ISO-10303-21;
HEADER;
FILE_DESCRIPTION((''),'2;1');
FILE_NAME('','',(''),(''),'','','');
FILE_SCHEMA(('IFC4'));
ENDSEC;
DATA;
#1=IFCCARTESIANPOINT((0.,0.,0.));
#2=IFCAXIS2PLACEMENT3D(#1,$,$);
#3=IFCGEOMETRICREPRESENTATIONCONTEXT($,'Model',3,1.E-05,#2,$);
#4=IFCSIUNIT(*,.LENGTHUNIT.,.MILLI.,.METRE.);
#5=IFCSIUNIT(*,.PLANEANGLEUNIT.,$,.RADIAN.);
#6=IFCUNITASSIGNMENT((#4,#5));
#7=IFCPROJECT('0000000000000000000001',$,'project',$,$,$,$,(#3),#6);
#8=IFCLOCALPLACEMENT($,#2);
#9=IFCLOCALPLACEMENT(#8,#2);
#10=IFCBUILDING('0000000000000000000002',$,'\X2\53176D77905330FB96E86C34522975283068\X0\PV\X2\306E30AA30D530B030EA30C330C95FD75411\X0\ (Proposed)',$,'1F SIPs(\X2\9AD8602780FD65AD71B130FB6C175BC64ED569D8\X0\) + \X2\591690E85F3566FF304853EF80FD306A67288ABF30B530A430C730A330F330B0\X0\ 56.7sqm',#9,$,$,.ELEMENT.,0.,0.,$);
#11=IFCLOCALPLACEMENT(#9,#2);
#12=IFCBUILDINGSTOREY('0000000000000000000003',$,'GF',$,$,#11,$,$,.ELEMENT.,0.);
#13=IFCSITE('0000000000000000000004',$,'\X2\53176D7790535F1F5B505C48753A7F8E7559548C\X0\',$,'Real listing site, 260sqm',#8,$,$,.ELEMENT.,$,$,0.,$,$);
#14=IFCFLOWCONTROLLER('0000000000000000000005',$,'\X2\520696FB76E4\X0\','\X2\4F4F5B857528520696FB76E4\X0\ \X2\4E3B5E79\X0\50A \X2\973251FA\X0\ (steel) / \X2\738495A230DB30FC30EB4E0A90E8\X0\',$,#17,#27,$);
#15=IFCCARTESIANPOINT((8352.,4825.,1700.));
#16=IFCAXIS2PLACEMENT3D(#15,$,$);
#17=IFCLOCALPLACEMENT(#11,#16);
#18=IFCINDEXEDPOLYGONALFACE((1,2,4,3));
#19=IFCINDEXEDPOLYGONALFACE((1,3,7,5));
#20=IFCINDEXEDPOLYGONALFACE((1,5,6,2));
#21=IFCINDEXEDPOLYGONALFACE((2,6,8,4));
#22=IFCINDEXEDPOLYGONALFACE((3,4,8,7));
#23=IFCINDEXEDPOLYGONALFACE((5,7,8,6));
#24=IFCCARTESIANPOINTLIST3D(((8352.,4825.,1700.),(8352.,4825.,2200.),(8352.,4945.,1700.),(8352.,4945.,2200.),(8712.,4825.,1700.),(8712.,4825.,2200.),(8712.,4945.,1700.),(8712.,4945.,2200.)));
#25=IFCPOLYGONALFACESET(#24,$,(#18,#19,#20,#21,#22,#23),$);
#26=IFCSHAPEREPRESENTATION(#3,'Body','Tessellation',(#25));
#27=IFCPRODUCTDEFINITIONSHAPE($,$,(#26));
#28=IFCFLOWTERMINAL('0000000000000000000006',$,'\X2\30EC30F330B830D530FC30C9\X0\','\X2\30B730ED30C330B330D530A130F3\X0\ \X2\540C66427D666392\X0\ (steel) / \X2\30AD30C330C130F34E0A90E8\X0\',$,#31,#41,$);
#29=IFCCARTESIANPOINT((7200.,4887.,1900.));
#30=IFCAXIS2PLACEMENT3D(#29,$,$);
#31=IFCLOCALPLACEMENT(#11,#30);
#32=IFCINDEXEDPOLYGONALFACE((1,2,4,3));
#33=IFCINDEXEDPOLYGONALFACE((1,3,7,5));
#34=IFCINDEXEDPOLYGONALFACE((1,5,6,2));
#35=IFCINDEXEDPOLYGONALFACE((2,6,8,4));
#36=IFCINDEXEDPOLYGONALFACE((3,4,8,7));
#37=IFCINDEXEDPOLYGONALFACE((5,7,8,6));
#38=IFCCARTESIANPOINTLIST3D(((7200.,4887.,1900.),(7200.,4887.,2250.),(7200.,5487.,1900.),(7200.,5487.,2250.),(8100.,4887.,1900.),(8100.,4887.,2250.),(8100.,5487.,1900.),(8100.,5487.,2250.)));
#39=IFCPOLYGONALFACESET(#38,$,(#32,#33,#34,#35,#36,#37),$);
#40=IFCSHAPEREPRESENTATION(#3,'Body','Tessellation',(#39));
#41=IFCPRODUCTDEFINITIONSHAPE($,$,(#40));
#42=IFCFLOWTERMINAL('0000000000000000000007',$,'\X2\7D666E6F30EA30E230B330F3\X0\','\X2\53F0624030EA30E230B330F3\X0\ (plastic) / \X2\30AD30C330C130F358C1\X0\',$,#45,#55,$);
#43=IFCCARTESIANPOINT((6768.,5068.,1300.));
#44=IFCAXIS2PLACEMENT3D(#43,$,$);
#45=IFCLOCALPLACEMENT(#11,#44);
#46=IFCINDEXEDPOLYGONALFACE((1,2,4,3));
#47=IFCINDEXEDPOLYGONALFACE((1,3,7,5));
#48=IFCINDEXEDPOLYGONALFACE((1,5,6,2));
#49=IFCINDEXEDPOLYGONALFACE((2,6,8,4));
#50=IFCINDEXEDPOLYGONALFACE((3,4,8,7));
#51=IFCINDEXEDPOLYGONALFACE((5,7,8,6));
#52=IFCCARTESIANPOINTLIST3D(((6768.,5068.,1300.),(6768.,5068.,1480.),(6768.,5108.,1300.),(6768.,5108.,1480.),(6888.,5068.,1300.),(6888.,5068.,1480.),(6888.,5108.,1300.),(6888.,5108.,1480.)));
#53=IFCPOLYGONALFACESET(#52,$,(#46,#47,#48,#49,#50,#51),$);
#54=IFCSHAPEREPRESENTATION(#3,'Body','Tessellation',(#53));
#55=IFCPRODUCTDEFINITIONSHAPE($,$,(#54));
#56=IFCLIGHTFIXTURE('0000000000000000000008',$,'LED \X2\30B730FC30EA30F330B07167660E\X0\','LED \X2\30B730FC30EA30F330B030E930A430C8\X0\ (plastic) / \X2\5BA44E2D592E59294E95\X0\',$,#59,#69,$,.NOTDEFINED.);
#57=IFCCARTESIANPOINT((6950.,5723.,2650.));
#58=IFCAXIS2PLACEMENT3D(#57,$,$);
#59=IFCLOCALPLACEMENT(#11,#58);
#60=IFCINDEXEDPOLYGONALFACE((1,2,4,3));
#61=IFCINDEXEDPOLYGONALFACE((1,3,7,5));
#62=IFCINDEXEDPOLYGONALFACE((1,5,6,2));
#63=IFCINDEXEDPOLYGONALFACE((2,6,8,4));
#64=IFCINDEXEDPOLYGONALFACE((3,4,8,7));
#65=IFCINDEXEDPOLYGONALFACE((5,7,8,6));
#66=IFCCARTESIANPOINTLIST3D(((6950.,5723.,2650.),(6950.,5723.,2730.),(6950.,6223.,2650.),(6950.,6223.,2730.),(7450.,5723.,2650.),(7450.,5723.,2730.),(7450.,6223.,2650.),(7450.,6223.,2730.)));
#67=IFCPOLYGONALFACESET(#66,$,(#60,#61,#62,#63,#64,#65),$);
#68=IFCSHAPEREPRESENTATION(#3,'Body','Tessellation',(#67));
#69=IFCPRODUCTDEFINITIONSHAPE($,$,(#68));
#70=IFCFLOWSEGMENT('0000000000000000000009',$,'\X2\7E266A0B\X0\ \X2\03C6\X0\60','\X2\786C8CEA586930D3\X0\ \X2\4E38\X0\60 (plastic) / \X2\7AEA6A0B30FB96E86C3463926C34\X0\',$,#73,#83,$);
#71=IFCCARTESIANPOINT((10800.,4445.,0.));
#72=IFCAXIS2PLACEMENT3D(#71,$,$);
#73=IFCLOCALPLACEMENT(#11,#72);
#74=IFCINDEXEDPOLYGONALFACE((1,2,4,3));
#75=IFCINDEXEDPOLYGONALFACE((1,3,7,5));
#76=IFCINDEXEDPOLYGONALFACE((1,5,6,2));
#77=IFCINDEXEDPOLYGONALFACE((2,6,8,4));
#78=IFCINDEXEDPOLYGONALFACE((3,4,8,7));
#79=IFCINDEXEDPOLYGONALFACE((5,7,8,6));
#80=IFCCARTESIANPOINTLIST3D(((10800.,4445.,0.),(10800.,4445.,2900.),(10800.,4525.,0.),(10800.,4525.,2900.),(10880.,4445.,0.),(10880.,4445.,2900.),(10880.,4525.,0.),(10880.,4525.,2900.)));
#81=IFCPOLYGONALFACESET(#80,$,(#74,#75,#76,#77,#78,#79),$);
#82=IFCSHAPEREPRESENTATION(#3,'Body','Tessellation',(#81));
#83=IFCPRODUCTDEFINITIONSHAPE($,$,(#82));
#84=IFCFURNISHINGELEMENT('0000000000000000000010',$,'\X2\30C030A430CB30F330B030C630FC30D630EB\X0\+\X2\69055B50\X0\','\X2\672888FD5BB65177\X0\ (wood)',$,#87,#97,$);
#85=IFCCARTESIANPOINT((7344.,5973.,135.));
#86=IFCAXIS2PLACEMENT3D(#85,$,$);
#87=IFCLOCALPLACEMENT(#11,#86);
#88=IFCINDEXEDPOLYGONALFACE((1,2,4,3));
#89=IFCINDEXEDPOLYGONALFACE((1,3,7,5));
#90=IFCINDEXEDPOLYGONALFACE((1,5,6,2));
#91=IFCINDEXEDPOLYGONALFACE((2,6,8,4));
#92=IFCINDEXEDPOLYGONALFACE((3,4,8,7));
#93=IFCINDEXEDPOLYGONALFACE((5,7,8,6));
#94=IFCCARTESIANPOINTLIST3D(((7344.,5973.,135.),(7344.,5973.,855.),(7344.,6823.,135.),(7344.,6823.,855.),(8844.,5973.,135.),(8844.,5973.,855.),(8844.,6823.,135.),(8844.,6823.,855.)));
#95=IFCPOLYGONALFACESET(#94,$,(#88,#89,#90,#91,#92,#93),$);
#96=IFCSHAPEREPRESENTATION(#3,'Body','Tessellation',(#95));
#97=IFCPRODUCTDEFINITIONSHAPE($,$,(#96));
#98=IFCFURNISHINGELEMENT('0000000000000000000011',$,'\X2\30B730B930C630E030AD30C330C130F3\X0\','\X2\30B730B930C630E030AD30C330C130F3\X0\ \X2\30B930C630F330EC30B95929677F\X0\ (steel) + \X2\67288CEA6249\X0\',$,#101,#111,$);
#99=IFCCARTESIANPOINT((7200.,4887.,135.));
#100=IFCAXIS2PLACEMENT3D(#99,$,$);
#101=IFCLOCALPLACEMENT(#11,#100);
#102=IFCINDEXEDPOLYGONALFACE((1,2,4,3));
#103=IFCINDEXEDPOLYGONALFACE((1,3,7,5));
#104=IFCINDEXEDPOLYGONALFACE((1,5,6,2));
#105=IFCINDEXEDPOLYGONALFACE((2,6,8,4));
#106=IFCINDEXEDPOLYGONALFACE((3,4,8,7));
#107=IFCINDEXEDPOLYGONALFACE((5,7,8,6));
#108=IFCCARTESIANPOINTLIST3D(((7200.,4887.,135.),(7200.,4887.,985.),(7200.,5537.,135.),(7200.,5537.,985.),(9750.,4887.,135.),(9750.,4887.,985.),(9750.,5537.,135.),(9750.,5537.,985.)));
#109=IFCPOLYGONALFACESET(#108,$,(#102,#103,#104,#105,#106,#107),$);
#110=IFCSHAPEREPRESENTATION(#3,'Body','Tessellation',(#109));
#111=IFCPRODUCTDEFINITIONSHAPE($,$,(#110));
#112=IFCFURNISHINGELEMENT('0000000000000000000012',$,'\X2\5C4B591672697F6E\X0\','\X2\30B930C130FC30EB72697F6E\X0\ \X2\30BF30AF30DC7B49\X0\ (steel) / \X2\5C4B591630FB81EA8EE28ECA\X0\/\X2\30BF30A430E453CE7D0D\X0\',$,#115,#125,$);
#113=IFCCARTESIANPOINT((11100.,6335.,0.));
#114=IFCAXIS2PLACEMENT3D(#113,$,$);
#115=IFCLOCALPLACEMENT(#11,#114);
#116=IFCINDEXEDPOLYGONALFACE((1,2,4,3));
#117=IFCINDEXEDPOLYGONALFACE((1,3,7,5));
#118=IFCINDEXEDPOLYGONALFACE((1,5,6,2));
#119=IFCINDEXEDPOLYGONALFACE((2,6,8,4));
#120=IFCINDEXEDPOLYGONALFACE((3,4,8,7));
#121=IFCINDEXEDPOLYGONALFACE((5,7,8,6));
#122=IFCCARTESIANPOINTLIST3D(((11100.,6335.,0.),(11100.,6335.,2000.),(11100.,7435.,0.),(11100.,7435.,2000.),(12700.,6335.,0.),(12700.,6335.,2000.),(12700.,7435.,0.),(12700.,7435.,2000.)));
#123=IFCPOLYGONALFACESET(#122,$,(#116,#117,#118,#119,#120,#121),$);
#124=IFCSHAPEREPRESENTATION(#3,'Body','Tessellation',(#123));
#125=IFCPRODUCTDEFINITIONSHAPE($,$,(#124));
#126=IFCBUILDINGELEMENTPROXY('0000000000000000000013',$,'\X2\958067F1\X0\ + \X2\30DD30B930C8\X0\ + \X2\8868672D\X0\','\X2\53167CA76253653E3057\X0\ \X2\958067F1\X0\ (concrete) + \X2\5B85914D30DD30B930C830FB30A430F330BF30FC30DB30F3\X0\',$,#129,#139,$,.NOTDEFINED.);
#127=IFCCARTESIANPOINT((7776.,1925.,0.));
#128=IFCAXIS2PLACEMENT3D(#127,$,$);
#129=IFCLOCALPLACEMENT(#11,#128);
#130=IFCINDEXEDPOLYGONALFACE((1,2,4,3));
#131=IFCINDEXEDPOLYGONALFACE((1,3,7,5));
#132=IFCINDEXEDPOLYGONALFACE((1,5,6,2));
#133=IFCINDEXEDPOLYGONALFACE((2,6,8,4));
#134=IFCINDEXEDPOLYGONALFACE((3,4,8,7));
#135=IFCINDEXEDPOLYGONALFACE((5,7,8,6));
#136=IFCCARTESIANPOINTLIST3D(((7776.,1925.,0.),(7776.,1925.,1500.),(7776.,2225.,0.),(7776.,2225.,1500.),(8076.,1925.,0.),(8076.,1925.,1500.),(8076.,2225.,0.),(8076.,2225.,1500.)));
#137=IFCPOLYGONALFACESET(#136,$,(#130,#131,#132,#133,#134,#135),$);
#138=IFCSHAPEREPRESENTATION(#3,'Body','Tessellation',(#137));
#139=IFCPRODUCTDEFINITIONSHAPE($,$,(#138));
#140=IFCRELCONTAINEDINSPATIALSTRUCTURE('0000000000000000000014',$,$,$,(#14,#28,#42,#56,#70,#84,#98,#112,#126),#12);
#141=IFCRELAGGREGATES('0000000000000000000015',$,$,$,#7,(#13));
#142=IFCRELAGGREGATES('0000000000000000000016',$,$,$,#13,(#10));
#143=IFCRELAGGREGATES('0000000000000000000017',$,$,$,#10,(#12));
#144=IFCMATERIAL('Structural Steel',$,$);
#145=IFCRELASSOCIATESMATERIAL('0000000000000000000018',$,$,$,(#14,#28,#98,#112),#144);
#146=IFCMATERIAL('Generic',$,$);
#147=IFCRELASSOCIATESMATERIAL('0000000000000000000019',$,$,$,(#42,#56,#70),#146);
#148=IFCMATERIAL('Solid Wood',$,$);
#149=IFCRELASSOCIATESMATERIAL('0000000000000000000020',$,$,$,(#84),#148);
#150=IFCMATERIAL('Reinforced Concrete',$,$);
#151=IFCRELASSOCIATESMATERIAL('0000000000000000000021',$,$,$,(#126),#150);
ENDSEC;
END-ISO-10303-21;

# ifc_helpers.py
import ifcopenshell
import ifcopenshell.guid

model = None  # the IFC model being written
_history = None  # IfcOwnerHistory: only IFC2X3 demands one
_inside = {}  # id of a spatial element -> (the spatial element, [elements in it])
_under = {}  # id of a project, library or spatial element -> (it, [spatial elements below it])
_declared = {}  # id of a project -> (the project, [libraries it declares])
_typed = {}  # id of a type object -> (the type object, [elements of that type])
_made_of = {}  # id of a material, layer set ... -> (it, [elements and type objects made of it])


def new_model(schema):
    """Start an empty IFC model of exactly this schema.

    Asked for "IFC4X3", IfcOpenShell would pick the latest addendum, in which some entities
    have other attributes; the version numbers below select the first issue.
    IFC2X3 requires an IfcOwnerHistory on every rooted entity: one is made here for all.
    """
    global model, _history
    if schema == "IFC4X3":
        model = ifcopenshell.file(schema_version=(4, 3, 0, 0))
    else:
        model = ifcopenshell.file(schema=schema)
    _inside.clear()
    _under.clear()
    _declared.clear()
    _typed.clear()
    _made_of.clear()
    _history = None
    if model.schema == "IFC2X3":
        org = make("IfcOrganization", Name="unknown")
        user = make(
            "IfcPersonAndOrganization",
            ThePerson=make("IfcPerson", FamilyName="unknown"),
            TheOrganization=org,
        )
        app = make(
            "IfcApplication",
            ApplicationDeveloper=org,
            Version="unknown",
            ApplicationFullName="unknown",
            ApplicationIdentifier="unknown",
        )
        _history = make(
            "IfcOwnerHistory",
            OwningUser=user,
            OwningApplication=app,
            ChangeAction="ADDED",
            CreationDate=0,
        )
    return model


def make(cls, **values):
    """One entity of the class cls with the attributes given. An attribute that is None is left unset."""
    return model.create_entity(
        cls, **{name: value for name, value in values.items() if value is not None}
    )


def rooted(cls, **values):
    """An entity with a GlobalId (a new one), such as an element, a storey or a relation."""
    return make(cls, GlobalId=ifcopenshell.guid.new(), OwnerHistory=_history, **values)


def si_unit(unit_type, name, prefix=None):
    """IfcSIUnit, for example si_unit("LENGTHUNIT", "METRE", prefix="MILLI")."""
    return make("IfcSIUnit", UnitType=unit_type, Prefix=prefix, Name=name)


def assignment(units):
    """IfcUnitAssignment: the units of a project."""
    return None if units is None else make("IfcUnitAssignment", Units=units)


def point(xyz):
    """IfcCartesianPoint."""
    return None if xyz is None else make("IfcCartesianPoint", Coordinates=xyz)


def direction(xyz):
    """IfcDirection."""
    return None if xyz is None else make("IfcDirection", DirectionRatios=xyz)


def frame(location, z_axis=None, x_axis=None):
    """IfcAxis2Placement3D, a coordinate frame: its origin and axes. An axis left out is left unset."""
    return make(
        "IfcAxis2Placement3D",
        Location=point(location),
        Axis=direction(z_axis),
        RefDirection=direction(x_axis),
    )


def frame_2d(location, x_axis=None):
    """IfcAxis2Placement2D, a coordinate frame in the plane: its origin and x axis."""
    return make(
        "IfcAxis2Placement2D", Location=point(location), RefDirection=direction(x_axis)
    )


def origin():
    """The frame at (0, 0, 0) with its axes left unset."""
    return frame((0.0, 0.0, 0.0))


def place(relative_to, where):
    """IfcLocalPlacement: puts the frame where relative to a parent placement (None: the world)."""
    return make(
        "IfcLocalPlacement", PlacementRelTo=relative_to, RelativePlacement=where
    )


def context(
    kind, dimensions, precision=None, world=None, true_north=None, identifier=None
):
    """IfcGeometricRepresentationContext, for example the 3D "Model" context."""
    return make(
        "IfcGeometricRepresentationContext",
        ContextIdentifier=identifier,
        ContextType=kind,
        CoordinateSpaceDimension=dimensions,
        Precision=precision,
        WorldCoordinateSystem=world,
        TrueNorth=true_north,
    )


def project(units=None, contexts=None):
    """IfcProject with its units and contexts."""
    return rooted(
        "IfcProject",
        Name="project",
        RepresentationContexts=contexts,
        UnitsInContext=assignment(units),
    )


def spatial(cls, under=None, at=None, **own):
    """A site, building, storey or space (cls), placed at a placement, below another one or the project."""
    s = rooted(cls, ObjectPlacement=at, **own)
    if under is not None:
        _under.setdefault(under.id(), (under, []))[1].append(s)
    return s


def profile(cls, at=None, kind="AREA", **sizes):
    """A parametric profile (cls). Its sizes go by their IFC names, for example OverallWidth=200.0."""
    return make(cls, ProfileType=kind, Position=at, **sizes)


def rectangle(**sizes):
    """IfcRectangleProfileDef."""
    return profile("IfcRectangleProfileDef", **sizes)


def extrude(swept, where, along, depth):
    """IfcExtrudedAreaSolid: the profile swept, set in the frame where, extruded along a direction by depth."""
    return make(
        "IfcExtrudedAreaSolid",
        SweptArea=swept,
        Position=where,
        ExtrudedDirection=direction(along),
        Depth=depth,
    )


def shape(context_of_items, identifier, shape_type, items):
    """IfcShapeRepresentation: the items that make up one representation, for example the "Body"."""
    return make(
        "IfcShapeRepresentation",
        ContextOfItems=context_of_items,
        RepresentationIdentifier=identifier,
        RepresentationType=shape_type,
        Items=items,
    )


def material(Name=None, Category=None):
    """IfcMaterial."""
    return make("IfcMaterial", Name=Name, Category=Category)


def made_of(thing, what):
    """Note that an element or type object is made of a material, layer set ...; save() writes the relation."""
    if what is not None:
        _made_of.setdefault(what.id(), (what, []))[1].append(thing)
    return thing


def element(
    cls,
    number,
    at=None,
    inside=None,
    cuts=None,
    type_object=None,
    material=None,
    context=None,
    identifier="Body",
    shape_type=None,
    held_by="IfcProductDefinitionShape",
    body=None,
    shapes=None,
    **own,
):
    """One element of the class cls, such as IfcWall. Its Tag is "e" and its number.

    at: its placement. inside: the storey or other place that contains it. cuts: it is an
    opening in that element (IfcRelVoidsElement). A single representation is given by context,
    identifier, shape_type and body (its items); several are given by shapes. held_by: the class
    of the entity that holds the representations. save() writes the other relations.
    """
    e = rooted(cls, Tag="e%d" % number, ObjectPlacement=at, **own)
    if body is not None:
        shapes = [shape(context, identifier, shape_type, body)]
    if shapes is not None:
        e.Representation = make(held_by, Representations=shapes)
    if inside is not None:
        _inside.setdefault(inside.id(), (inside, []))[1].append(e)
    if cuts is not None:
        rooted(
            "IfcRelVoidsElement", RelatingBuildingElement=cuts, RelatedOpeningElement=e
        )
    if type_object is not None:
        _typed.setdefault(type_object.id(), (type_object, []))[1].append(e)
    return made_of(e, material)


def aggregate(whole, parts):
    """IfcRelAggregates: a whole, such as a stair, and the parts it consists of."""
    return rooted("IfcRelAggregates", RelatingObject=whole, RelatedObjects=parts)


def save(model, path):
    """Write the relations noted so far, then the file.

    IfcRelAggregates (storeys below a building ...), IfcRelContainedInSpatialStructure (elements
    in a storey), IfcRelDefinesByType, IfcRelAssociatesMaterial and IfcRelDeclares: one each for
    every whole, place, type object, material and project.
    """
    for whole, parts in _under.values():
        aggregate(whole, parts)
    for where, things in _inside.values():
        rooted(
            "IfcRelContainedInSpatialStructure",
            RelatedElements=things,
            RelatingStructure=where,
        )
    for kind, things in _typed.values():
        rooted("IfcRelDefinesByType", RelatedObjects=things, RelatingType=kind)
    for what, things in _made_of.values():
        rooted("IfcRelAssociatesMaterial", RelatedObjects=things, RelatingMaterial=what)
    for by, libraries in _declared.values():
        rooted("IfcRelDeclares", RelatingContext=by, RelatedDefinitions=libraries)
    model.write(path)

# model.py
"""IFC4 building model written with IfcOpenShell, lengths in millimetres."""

from ifc_helpers import new_model, si_unit, frame, frame_2d, origin, place, context, project, spatial, rectangle, extrude, material, element, save


model = new_model("IFC4")

# Units and contexts
model_context = context("Model", 3, precision=1e-05, world=origin())
ifc_project = project(units=[si_unit("LENGTHUNIT", "METRE", prefix="MILLI"), si_unit("PLANEANGLEUNIT", "RADIAN")], contexts=[model_context])

# Site, building, storey
site_placement = place(None, origin())
site = spatial("IfcSite", under=ifc_project, at=site_placement, Name="北海道弟子屈町美留和", ObjectType="Real listing site, 260sqm", CompositionType="ELEMENT", RefElevation=0.0)
building_placement = place(site_placement, origin())
building = spatial("IfcBuilding", under=site, at=building_placement, Name="北海道・雨水利用とPVのオフグリッド志向 (Proposed)", ObjectType="1F SIPs(高性能断熱・気密仕様) + 外部張替え可能な木調サイディング 56.7sqm", CompositionType="ELEMENT", ElevationOfRefHeight=0.0, ElevationOfTerrain=0.0)
storey_placement = place(building_placement, origin())
storey = spatial("IfcBuildingStorey", under=building, at=storey_placement, Name="GF", CompositionType="ELEMENT", Elevation=0.0)

# Shared definitions
ifc_material_1 = material(Name="Solid Wood")

# Shared definitions
ifc_material_2 = material(Name="Structural Steel")

# Shared definitions
ifc_material_3 = material(Name="Reinforced Concrete")

# Flow controller
flow_controller_placement = place(storey_placement, frame((8352.0, 4825.0, 1700.0)))
element("IfcFlowController", 1, at=flow_controller_placement, inside=storey, material=ifc_material_2, Name="分電盤", Description="住宅用分電盤 主幹50A 露出 (steel) / 玄関ホール上部", context=model_context, shape_type="SweptSolid", body=[
    extrude(rectangle(XDim=360.0, YDim=120.0, at=frame_2d((180.0, 60.0))), frame((8352.0, 4825.0, 1700.0)), (0.0, 0.0, 1.0), 500.0),
])

# Flow terminals
flow_terminal_1_placement = place(storey_placement, frame((7200.0, 4887.0, 1900.0)))
element("IfcFlowTerminal", 2, at=flow_terminal_1_placement, inside=storey, material=ifc_material_2, Name="レンジフード", Description="シロッコファン 同時給排 (steel) / キッチン上部", context=model_context, shape_type="SweptSolid", body=[
    extrude(rectangle(XDim=900.0, YDim=600.0, at=frame_2d((450.0, 300.0))), frame((7200.0, 4887.0, 1900.0)), (0.0, 0.0, 1.0), 350.0),
])
ifc_material_4 = material(Name="Generic")
flow_terminal_2_placement = place(storey_placement, frame((6768.0, 5068.0, 1300.0)))
element("IfcFlowTerminal", 3, at=flow_terminal_2_placement, inside=storey, material=ifc_material_4, Name="給湯リモコン", Description="台所リモコン (plastic) / キッチン壁", context=model_context, shape_type="SweptSolid", body=[
    extrude(rectangle(XDim=120.0, YDim=40.0, at=frame_2d((60.0, 20.0))), frame((6768.0, 5068.0, 1300.0)), (0.0, 0.0, 1.0), 180.0),
])

# Light fixture
light_fixture_placement = place(storey_placement, frame((6950.0, 5723.0, 2650.0)))
element("IfcLightFixture", 4, at=light_fixture_placement, inside=storey, material=ifc_material_4, Name="LED シーリング照明", Description="LED シーリングライト (plastic) / 室中央天井", PredefinedType="NOTDEFINED", context=model_context, shape_type="SweptSolid", body=[
    extrude(rectangle(XDim=500.0, YDim=500.0, at=frame_2d((250.0, 250.0))), frame((6950.0, 5723.0, 2650.0)), (0.0, 0.0, 1.0), 80.0),
])

# Flow segment
flow_segment_placement = place(storey_placement, frame((10800.0, 4445.0, 0.0)))
element("IfcFlowSegment", 5, at=flow_segment_placement, inside=storey, material=ifc_material_4, Name="縦樋 φ60", Description="硬質塩ビ 丸60 (plastic) / 竪樋・雨水排水", context=model_context, shape_type="SweptSolid", body=[
    extrude(rectangle(XDim=80.0, YDim=80.0, at=frame_2d((40.0, 40.0))), frame((10800.0, 4445.0, 0.0)), (0.0, 0.0, 1.0), 2900.0),
])

# Furnishing elements
furnishing_1_placement = place(storey_placement, frame((7344.0, 5973.0, 135.0)))
element("IfcFurnishingElement", 6, at=furnishing_1_placement, inside=storey, material=ifc_material_1, Name="ダイニングテーブル+椅子", Description="木製家具 (wood)", context=model_context, shape_type="SweptSolid", body=[
    extrude(rectangle(XDim=1500.0, YDim=850.0, at=frame_2d((750.0, 425.0))), frame((7344.0, 5973.0, 135.0)), (0.0, 0.0, 1.0), 720.0),
])
furnishing_2_placement = place(storey_placement, frame((7200.0, 4887.0, 135.0)))
element("IfcFurnishingElement", 7, at=furnishing_2_placement, inside=storey, material=ifc_material_2, Name="システムキッチン", Description="システムキッチン ステンレス天板 (steel) + 木質扉", context=model_context, shape_type="SweptSolid", body=[
    extrude(rectangle(XDim=2550.0, YDim=650.0, at=frame_2d((1275.0, 325.0))), frame((7200.0, 4887.0, 135.0)), (0.0, 0.0, 1.0), 850.0),
])
furnishing_3_placement = place(storey_placement, frame((11100.0, 6335.0, 0.0)))
element("IfcFurnishingElement", 8, at=furnishing_3_placement, inside=storey, material=ifc_material_2, Name="屋外物置", Description="スチール物置 タクボ等 (steel) / 屋外・自転車/タイヤ収納", context=model_context, shape_type="SweptSolid", body=[
    extrude(rectangle(XDim=1600.0, YDim=1100.0, at=frame_2d((800.0, 550.0))), frame((11100.0, 6335.0, 0.0)), (0.0, 0.0, 1.0), 2000.0),
])

# Building element proxy
proxy_placement = place(storey_placement, frame((7776.0, 1925.0, 0.0)))
element("IfcBuildingElementProxy", 9, at=proxy_placement, inside=storey, material=ifc_material_3, Name="門柱 + ポスト + 表札", Description="化粧打放し 門柱 (concrete) + 宅配ポスト・インターホン", PredefinedType="NOTDEFINED", context=model_context, shape_type="SweptSolid", body=[
    extrude(rectangle(XDim=300.0, YDim=300.0, at=frame_2d((150.0, 150.0))), frame((7776.0, 1925.0, 0.0)), (0.0, 0.0, 1.0), 1500.0),
])

save(model, "model.ifc")
